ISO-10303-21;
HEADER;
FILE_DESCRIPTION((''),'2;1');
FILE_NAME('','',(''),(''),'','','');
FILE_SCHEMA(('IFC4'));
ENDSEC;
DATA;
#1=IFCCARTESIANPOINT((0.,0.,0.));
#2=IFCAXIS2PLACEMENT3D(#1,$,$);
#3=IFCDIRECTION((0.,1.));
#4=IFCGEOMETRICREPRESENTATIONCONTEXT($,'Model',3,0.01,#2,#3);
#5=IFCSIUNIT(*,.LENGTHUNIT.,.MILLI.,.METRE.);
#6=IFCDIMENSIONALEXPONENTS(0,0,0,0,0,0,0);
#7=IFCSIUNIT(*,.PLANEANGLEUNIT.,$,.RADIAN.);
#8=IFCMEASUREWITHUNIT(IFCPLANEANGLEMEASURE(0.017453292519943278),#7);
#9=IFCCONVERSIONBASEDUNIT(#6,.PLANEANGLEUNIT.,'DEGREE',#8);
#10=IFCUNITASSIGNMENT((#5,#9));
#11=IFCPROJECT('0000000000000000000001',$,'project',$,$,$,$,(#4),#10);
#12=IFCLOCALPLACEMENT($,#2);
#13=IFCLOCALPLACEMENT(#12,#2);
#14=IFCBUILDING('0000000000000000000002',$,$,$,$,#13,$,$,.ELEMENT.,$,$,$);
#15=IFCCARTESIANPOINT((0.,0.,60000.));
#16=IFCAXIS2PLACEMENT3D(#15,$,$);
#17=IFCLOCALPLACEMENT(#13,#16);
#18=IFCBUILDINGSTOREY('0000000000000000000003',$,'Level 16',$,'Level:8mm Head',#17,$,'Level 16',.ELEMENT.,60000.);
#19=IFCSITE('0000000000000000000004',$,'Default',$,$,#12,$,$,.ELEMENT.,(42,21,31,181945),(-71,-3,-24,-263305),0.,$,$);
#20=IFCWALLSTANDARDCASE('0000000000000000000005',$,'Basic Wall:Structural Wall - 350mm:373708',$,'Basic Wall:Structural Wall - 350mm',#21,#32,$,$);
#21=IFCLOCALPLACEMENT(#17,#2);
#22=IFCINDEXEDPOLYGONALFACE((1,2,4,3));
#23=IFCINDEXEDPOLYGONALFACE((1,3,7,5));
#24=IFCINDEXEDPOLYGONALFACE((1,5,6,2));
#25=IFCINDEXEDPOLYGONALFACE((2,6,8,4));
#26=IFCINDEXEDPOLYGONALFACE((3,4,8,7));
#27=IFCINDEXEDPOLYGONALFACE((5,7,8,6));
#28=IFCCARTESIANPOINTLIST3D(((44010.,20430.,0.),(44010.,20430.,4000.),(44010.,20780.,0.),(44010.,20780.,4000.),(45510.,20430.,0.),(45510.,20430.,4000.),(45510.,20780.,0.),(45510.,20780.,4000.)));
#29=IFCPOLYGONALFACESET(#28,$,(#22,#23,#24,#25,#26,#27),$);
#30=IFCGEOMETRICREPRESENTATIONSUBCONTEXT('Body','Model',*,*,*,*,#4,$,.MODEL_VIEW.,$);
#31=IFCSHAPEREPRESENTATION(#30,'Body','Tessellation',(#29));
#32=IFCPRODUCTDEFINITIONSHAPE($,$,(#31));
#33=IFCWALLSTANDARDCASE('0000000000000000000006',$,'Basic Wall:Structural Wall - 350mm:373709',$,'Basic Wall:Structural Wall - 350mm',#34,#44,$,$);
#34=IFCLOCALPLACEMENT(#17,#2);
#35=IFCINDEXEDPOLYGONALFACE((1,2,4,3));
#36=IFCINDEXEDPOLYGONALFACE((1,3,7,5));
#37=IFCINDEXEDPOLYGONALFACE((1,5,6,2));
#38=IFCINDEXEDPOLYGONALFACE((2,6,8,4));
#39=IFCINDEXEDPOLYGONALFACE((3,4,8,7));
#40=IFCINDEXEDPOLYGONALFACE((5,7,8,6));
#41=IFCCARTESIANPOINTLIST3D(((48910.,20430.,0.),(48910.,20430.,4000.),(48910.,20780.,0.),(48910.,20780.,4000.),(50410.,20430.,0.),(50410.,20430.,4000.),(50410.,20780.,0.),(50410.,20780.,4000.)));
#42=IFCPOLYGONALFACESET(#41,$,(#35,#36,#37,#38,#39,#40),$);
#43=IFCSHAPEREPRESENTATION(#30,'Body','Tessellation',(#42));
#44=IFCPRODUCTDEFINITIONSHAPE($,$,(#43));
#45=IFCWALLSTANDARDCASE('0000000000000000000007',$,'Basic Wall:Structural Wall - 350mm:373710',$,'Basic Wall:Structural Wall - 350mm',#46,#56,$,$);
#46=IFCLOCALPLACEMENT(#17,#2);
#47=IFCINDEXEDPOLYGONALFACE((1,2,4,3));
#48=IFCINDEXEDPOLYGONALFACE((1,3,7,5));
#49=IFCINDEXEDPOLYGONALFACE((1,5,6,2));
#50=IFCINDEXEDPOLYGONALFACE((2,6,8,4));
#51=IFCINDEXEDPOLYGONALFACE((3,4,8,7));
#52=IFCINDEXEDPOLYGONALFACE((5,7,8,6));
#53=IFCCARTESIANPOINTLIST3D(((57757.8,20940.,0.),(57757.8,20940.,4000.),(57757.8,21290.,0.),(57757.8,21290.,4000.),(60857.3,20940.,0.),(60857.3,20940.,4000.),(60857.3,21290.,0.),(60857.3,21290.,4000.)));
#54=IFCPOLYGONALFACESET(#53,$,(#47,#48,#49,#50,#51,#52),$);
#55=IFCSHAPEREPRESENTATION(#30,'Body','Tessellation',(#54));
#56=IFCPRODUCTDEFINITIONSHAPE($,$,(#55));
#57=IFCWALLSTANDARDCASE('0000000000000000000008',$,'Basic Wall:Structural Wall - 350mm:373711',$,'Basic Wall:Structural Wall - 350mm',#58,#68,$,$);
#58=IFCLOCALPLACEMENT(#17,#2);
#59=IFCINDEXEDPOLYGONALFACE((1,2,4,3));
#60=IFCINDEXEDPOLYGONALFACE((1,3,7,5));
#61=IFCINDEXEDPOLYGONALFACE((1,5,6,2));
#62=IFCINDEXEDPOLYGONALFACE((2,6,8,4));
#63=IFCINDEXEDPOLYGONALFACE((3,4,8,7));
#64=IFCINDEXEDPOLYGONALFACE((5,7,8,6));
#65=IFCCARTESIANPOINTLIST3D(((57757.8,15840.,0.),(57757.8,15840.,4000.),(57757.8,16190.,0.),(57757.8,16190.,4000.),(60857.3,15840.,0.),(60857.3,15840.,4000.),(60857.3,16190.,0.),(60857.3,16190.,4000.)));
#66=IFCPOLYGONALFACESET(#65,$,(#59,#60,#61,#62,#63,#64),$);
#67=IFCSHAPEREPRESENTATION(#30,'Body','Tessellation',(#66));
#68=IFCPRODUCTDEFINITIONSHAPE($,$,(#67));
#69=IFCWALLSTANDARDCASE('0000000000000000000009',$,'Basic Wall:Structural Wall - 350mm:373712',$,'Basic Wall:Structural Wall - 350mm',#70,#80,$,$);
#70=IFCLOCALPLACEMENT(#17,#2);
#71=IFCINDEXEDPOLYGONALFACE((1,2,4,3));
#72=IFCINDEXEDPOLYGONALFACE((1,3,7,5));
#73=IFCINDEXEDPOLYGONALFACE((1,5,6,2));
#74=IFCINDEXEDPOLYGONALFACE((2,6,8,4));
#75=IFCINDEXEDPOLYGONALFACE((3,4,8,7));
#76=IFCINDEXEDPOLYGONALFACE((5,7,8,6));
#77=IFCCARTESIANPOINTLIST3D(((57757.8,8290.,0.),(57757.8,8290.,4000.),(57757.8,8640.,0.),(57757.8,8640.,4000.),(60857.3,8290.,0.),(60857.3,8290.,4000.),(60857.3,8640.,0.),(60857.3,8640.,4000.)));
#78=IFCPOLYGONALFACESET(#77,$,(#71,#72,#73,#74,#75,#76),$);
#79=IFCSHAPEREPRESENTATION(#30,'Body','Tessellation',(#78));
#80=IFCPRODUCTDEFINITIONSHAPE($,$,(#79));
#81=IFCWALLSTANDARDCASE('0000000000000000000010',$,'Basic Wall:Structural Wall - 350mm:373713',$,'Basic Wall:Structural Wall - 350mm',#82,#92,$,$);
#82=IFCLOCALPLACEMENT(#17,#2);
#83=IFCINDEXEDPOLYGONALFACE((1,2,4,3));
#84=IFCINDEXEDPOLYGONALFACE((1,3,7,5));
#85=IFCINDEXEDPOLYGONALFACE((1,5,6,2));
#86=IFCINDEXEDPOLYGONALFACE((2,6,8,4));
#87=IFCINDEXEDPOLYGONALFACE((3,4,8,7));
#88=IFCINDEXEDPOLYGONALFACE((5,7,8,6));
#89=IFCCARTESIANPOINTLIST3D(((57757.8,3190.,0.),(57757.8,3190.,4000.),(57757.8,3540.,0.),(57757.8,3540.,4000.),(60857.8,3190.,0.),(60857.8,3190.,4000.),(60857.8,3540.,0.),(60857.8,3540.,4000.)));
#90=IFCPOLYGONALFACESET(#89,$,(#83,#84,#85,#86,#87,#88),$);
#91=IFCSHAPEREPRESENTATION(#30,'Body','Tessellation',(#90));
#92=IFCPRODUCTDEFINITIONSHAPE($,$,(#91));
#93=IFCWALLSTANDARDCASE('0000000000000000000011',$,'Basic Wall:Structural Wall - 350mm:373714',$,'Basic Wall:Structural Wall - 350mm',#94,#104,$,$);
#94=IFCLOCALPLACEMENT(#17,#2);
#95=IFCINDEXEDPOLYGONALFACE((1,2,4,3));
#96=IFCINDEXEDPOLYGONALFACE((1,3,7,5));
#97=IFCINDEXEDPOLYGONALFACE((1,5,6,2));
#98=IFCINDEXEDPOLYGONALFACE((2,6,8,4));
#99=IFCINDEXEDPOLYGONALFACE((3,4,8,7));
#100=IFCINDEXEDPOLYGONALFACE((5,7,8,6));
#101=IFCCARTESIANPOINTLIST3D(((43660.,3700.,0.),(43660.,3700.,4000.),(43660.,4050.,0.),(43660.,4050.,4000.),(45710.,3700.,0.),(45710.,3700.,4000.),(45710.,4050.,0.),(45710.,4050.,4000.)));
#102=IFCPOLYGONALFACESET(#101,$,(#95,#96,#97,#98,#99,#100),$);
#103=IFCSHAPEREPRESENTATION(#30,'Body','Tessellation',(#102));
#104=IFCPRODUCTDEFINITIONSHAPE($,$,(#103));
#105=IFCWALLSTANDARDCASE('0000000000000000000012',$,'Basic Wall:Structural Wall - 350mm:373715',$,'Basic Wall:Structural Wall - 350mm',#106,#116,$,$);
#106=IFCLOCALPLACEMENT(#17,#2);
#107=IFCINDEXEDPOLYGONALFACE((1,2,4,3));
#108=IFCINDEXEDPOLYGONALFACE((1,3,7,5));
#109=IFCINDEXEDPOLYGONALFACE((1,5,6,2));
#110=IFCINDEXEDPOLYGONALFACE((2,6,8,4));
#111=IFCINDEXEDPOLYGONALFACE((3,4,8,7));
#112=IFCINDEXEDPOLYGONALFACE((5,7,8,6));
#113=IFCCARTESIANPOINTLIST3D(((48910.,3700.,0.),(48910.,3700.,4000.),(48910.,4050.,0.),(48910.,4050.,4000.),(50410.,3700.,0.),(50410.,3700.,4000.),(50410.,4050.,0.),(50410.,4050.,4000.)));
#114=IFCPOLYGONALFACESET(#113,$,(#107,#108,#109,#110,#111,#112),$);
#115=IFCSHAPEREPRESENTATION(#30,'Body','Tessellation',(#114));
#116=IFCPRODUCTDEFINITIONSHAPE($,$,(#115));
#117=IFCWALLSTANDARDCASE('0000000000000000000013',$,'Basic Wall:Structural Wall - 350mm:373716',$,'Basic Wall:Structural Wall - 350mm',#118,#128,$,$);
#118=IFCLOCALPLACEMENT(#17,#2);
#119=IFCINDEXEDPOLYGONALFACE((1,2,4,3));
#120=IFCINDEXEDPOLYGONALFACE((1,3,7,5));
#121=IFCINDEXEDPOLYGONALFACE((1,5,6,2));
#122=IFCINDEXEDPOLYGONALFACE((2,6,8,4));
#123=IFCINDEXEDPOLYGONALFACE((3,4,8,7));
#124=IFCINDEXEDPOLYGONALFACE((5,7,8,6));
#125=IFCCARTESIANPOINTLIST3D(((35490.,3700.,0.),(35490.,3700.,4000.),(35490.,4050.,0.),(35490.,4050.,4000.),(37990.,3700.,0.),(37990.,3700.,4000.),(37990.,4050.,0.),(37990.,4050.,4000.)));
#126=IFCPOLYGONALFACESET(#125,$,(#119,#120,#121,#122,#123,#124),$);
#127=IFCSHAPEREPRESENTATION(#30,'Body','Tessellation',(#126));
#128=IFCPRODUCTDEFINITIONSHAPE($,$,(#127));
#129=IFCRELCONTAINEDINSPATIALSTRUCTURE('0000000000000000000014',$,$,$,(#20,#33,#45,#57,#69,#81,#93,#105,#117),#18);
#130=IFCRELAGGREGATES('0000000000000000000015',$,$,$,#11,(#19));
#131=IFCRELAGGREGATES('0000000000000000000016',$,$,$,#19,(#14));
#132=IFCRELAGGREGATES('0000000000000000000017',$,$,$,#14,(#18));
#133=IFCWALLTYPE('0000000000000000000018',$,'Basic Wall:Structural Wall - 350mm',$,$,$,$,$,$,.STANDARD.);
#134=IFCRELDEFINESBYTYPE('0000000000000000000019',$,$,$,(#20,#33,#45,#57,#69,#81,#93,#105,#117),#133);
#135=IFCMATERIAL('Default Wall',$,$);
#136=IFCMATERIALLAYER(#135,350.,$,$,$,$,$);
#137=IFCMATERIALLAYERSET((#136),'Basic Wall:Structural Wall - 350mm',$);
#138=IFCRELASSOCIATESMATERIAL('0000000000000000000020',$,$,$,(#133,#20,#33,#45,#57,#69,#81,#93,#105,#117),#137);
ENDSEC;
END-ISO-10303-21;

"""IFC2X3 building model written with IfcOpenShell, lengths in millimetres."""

from ifc_helpers import new_model, entity, si_unit, converted_unit, direction, frame, frame_2d, origin, place, context, subcontext, project, spatial, rectangle, extrude, material, layer, layer_set, layer_usage, type_object, element, save


model = new_model("IFC2X3")

# Units and contexts
model_context = context("Model", 3, precision=0.01, world=origin(), true_north=direction((0.0, 1.0)))
body_context = subcontext(model_context, "Body", "Model", "MODEL_VIEW")
ifc_project = project(units=[si_unit("LENGTHUNIT", "METRE", prefix="MILLI"), converted_unit("PLANEANGLEUNIT", "DEGREE", entity("IfcPlaneAngleMeasure", 0.017453292519943278), si_unit("PLANEANGLEUNIT", "RADIAN"), dimensions=[0, 0, 0, 0, 0, 0, 0])], contexts=[model_context])

# Site, building, storey
site_placement = place(None, origin())
site = spatial("IfcSite", under=ifc_project, at=site_placement, Name="Default", CompositionType="ELEMENT", RefLatitude=(42, 21, 31, 181945), RefLongitude=(-71, -3, -24, -263305), RefElevation=0.0)
building_placement = place(site_placement, origin())
building = spatial("IfcBuilding", under=site, at=building_placement, CompositionType="ELEMENT")
storey_placement = place(building_placement, frame((0.0, 0.0, 60000.0)))
storey = spatial("IfcBuildingStorey", under=building, at=storey_placement, Name="Level 16", ObjectType="Level:8mm Head", LongName="Level 16", CompositionType="ELEMENT", Elevation=60000.0)

# Walls
ifc_material_1 = material(Name="Default Wall")
ifc_layer_1 = layer(ifc_material_1, 350.0)
ifc_layer_set_1 = layer_set([ifc_layer_1], Name="Basic Wall:Structural Wall - 350mm")
wall_type_1 = type_object("IfcWallType", Name="Basic Wall:Structural Wall - 350mm", PredefinedType="STANDARD", material=ifc_layer_set_1)
ifc_layer_usage_1 = layer_usage(ifc_layer_set_1, "AXIS2", "NEGATIVE", 175.0)
wall_1_placement = place(storey_placement, frame((44010.0, 20605.0, 0.0)))
element("IfcWallStandardCase", 1, at=wall_1_placement, inside=storey, type_object=wall_type_1, material=ifc_layer_usage_1, Name="Basic Wall:Structural Wall - 350mm:373708", ObjectType="Basic Wall:Structural Wall - 350mm", context=body_context, shape_type="SweptSolid", body=[
    extrude(rectangle(XDim=1500.0, YDim=350.0, at=frame_2d((750.0, 0.0), x_axis=(-1.0, 0.0))), origin(), (0.0, 0.0, 1.0), 4000.0),
])
ifc_layer_usage_2 = layer_usage(ifc_layer_set_1, "AXIS2", "NEGATIVE", 175.0)
wall_2_placement = place(storey_placement, frame((48910.0, 20605.0, 0.0)))
element("IfcWallStandardCase", 2, at=wall_2_placement, inside=storey, type_object=wall_type_1, material=ifc_layer_usage_2, Name="Basic Wall:Structural Wall - 350mm:373709", ObjectType="Basic Wall:Structural Wall - 350mm", context=body_context, shape_type="SweptSolid", body=[
    extrude(rectangle(XDim=1500.0, YDim=350.0, at=frame_2d((750.0, 0.0), x_axis=(-1.0, 0.0))), origin(), (0.0, 0.0, 1.0), 4000.0),
])
ifc_layer_usage_3 = layer_usage(ifc_layer_set_1, "AXIS2", "NEGATIVE", 175.0)
wall_3_placement = place(storey_placement, frame((57757.8, 21115.0, 0.0)))
element("IfcWallStandardCase", 3, at=wall_3_placement, inside=storey, type_object=wall_type_1, material=ifc_layer_usage_3, Name="Basic Wall:Structural Wall - 350mm:373710", ObjectType="Basic Wall:Structural Wall - 350mm", context=body_context, shape_type="SweptSolid", body=[
    extrude(rectangle(XDim=3099.5, YDim=350.0, at=frame_2d((1549.8, 0.0), x_axis=(-1.0, 0.0))), origin(), (0.0, 0.0, 1.0), 4000.0),
])
ifc_layer_usage_4 = layer_usage(ifc_layer_set_1, "AXIS2", "NEGATIVE", 175.0)
wall_4_placement = place(storey_placement, frame((57757.8, 16015.0, 0.0)))
element("IfcWallStandardCase", 4, at=wall_4_placement, inside=storey, type_object=wall_type_1, material=ifc_layer_usage_4, Name="Basic Wall:Structural Wall - 350mm:373711", ObjectType="Basic Wall:Structural Wall - 350mm", context=body_context, shape_type="SweptSolid", body=[
    extrude(rectangle(XDim=3099.5, YDim=350.0, at=frame_2d((1549.8, 0.0), x_axis=(-1.0, 0.0))), origin(), (0.0, 0.0, 1.0), 4000.0),
])
ifc_layer_usage_5 = layer_usage(ifc_layer_set_1, "AXIS2", "POSITIVE", -175.0)
wall_5_placement = place(storey_placement, frame((57757.8, 8465.0, 0.0)))
element("IfcWallStandardCase", 5, at=wall_5_placement, inside=storey, type_object=wall_type_1, material=ifc_layer_usage_5, Name="Basic Wall:Structural Wall - 350mm:373712", ObjectType="Basic Wall:Structural Wall - 350mm", context=body_context, shape_type="SweptSolid", body=[
    extrude(rectangle(XDim=3099.5, YDim=350.0, at=frame_2d((1549.8, 0.0), x_axis=(-1.0, 0.0))), origin(), (0.0, 0.0, 1.0), 4000.0),
])
ifc_layer_usage_6 = layer_usage(ifc_layer_set_1, "AXIS2", "POSITIVE", -175.0)
wall_6_placement = place(storey_placement, frame((57757.8, 3365.0, 0.0)))
element("IfcWallStandardCase", 6, at=wall_6_placement, inside=storey, type_object=wall_type_1, material=ifc_layer_usage_6, Name="Basic Wall:Structural Wall - 350mm:373713", ObjectType="Basic Wall:Structural Wall - 350mm", context=body_context, shape_type="SweptSolid", body=[
    extrude(rectangle(XDim=3100.0, YDim=350.0, at=frame_2d((1550.0, 0.0), x_axis=(-1.0, 0.0))), origin(), (0.0, 0.0, 1.0), 4000.0),
])
ifc_layer_usage_7 = layer_usage(ifc_layer_set_1, "AXIS2", "POSITIVE", -175.0)
wall_7_placement = place(storey_placement, frame((43660.0, 3875.0, 0.0)))
element("IfcWallStandardCase", 7, at=wall_7_placement, inside=storey, type_object=wall_type_1, material=ifc_layer_usage_7, Name="Basic Wall:Structural Wall - 350mm:373714", ObjectType="Basic Wall:Structural Wall - 350mm", context=body_context, shape_type="SweptSolid", body=[
    extrude(rectangle(XDim=2050.0, YDim=350.0, at=frame_2d((1025.0, 0.0), x_axis=(-1.0, 0.0))), origin(), (0.0, 0.0, 1.0), 4000.0),
])
ifc_layer_usage_8 = layer_usage(ifc_layer_set_1, "AXIS2", "POSITIVE", -175.0)
wall_8_placement = place(storey_placement, frame((48910.0, 3875.0, 0.0)))
element("IfcWallStandardCase", 8, at=wall_8_placement, inside=storey, type_object=wall_type_1, material=ifc_layer_usage_8, Name="Basic Wall:Structural Wall - 350mm:373715", ObjectType="Basic Wall:Structural Wall - 350mm", context=body_context, shape_type="SweptSolid", body=[
    extrude(rectangle(XDim=1500.0, YDim=350.0, at=frame_2d((750.0, 0.0), x_axis=(-1.0, 0.0))), origin(), (0.0, 0.0, 1.0), 4000.0),
])
ifc_layer_usage_9 = layer_usage(ifc_layer_set_1, "AXIS2", "POSITIVE", -175.0)
wall_9_placement = place(storey_placement, frame((35490.0, 3875.0, 0.0)))
element("IfcWallStandardCase", 9, at=wall_9_placement, inside=storey, type_object=wall_type_1, material=ifc_layer_usage_9, Name="Basic Wall:Structural Wall - 350mm:373716", ObjectType="Basic Wall:Structural Wall - 350mm", context=body_context, shape_type="SweptSolid", body=[
    extrude(rectangle(XDim=2500.0, YDim=350.0, at=frame_2d((1250.0, 0.0), x_axis=(-1.0, 0.0))), origin(), (0.0, 0.0, 1.0), 4000.0),
])

save(model, "model.ifc")
